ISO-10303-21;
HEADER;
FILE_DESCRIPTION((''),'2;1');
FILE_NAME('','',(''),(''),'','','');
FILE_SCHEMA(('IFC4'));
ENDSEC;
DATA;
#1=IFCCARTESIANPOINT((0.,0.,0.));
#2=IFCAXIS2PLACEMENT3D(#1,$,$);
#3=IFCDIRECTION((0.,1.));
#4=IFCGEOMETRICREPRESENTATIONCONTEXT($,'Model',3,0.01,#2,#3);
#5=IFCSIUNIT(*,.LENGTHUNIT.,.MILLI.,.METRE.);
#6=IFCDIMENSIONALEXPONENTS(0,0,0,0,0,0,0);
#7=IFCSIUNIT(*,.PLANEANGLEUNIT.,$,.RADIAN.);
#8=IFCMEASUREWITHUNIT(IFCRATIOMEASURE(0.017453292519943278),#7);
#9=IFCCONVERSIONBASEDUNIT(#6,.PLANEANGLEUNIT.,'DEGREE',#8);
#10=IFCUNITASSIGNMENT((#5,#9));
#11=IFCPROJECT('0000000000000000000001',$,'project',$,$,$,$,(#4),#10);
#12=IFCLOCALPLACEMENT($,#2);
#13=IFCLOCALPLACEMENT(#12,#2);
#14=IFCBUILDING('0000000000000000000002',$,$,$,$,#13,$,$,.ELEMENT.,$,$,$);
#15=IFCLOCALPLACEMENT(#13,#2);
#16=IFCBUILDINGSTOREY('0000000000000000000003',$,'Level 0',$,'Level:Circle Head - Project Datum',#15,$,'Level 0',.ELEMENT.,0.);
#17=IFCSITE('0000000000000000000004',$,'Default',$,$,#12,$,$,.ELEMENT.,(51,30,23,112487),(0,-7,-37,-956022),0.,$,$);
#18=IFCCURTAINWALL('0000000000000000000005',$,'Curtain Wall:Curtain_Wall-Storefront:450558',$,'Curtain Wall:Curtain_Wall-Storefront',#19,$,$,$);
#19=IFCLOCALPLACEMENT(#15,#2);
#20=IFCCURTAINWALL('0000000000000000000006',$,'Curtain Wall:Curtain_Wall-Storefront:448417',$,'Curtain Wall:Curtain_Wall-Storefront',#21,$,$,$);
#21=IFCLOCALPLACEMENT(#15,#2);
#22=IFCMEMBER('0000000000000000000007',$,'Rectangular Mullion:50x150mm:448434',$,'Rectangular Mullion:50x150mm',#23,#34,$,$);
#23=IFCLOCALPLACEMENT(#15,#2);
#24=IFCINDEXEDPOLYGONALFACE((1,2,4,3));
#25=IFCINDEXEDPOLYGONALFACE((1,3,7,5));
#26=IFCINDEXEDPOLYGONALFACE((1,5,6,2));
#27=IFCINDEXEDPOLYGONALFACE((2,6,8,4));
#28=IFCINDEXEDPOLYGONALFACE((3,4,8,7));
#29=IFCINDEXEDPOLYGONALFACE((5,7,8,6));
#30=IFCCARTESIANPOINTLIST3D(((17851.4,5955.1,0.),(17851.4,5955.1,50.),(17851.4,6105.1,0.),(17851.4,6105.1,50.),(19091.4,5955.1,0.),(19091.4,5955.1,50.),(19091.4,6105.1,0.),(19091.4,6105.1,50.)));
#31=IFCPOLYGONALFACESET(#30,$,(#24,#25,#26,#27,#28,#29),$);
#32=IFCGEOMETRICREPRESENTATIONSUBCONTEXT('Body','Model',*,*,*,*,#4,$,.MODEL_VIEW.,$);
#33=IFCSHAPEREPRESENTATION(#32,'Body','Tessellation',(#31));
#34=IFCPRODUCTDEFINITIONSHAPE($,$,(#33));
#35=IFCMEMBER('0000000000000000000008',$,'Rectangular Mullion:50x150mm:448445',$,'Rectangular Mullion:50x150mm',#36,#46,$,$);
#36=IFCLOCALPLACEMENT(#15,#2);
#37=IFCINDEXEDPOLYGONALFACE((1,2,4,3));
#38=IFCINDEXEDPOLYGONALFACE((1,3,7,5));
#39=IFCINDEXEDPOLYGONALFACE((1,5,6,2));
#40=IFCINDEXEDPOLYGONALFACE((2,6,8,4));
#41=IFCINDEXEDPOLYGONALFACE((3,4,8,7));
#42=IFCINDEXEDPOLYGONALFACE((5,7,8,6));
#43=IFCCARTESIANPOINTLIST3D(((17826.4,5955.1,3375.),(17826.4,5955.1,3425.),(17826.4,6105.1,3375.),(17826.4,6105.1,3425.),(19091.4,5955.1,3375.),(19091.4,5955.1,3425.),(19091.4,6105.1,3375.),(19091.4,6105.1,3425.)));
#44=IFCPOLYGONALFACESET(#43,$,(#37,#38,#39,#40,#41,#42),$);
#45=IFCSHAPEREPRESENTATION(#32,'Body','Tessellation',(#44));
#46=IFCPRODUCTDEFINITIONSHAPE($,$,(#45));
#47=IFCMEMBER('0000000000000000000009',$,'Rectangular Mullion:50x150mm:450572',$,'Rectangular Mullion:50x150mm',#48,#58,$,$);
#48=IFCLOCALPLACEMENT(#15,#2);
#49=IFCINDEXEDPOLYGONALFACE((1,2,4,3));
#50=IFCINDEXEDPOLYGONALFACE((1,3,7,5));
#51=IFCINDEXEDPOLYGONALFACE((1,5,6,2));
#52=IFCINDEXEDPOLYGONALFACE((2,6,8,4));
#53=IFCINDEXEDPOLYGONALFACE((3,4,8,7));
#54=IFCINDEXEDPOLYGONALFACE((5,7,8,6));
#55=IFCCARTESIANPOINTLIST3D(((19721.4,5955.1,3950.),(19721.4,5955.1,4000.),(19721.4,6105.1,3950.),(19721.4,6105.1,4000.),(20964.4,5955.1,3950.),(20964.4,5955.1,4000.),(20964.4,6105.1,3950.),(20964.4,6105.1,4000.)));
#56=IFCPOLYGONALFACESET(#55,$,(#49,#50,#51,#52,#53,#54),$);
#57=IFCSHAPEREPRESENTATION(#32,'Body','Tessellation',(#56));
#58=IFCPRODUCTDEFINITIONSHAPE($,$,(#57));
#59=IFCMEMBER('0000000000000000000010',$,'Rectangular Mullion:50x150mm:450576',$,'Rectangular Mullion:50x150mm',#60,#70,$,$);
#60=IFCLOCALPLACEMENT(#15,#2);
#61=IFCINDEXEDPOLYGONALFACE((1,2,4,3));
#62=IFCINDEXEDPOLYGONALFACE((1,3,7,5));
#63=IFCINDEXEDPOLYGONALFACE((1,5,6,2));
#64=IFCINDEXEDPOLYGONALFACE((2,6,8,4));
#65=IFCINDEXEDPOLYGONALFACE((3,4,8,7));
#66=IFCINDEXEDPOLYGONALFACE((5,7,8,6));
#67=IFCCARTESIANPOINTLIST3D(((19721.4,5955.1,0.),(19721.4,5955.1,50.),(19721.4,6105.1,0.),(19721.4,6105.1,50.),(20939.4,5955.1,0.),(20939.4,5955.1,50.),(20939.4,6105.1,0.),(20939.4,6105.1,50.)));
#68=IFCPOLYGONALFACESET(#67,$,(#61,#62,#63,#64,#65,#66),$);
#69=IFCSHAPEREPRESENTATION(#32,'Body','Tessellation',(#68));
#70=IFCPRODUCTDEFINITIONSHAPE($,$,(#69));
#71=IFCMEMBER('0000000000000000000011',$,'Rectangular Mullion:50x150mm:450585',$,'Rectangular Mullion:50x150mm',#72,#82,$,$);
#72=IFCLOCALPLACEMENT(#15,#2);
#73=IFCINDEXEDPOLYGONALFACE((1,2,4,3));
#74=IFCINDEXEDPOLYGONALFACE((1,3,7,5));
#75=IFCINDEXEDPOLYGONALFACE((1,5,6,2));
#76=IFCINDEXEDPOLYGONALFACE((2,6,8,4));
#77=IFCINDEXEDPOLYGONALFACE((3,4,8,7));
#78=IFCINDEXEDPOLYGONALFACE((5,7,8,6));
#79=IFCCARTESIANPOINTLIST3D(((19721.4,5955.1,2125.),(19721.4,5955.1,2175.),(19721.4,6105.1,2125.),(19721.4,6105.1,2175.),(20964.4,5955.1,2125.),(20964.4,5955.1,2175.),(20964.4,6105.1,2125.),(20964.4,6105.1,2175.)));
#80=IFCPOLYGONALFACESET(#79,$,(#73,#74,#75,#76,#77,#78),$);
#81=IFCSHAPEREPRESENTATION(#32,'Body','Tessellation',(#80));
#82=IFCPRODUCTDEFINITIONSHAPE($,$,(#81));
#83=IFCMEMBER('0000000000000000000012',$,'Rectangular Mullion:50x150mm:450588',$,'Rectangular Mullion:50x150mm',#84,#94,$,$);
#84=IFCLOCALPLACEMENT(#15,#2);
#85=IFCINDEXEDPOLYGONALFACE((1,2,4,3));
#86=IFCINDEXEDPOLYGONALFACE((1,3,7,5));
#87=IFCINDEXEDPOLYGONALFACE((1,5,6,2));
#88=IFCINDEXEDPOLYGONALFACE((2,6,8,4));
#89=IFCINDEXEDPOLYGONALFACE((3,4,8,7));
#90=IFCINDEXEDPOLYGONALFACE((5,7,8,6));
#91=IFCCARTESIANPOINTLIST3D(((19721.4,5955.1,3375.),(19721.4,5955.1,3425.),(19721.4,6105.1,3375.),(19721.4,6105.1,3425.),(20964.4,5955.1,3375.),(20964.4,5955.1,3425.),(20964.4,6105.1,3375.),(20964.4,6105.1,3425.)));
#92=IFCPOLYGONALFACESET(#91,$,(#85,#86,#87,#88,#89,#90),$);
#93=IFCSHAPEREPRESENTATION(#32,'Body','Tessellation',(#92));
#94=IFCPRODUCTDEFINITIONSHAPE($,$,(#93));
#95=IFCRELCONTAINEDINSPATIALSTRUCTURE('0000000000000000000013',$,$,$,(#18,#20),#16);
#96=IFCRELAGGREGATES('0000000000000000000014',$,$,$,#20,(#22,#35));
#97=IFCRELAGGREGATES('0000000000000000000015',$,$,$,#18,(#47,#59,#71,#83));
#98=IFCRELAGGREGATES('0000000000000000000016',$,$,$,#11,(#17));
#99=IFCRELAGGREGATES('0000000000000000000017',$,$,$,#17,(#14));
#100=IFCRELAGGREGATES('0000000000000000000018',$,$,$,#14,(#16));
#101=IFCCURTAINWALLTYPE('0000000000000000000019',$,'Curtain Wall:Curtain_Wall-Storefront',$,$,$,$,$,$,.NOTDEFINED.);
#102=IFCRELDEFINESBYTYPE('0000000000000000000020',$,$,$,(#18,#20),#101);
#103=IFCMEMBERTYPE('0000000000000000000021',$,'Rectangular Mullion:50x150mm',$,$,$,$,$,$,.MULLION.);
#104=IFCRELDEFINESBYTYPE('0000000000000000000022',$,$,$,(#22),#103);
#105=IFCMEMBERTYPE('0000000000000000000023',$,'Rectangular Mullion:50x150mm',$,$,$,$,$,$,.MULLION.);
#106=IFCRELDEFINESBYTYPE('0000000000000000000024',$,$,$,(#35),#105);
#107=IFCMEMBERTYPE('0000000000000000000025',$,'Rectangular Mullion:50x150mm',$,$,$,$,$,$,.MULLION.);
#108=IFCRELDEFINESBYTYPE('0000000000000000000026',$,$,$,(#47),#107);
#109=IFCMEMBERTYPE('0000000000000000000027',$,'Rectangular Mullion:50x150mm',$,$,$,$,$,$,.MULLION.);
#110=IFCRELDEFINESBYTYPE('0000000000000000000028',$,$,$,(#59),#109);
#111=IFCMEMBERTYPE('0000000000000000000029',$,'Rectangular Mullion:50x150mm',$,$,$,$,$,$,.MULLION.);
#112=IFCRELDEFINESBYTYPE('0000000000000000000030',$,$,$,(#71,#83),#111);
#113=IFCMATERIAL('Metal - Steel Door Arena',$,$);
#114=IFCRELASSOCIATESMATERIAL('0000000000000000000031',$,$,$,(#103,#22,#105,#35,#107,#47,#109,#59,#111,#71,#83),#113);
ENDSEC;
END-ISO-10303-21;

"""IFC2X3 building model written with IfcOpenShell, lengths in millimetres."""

from ifc_helpers import new_model, entity, si_unit, converted_unit, direction, frame, origin, origin_2d_with_axis, place, context, subcontext, project, spatial, rectangle, extrude, source, transform, mapped, material, type_object, type_shapes, element, aggregate, save


model = new_model("IFC2X3")

# Units and contexts
model_context = context("Model", 3, precision=0.01, world=origin(), true_north=direction((0.0, 1.0)))
body_context = subcontext(model_context, "Body", "Model", "MODEL_VIEW")
ifc_project = project(units=[si_unit("LENGTHUNIT", "METRE", prefix="MILLI"), converted_unit("PLANEANGLEUNIT", "DEGREE", entity("IfcRatioMeasure", 0.017453292519943278), si_unit("PLANEANGLEUNIT", "RADIAN"), dimensions=[0, 0, 0, 0, 0, 0, 0])], contexts=[model_context])

# Site, building, storey
site_placement = place(None, origin())
site = spatial("IfcSite", under=ifc_project, at=site_placement, Name="Default", CompositionType="ELEMENT", RefLatitude=(51, 30, 23, 112487), RefLongitude=(0, -7, -37, -956022), RefElevation=0.0)
building_placement = place(site_placement, origin())
building = spatial("IfcBuilding", under=site, at=building_placement, CompositionType="ELEMENT")
storey_placement = place(building_placement, origin())
storey = spatial("IfcBuildingStorey", under=building, at=storey_placement, Name="Level 0", ObjectType="Level:Circle Head - Project Datum", LongName="Level 0", CompositionType="ELEMENT", Elevation=0.0)

# Curtain walls
curtain_wall_type = type_object("IfcCurtainWallType", Name="Curtain Wall:Curtain_Wall-Storefront", PredefinedType="NOTDEFINED")
curtain_wall_1_placement = place(storey_placement, origin())
curtain_wall_1 = element("IfcCurtainWall", 1, at=curtain_wall_1_placement, inside=storey, type_object=curtain_wall_type, Name="Curtain Wall:Curtain_Wall-Storefront:450558", ObjectType="Curtain Wall:Curtain_Wall-Storefront")
ifc_material_1 = material(Name="Metal - Steel Door Arena")
curtain_wall_2_placement = place(storey_placement, origin())
curtain_wall_2 = element("IfcCurtainWall", 2, at=curtain_wall_2_placement, inside=storey, type_object=curtain_wall_type, Name="Curtain Wall:Curtain_Wall-Storefront:448417", ObjectType="Curtain Wall:Curtain_Wall-Storefront")

# Members
member_type_1 = type_object("IfcMemberType", Name="Rectangular Mullion:50x150mm", PredefinedType="MULLION", material=ifc_material_1)
shared_shape_1 = source(origin(), body_context, "Body", "SweptSolid", [
    extrude(rectangle(XDim=150.0, YDim=50.0, at=origin_2d_with_axis()), frame((-25.0, 0.0, -1240.0), z_axis=(0.0, 0.0, 1.0), x_axis=(0.0, -1.0, 0.0)), (0.0, 0.0, 1.0), 1240.0),
])
type_shapes(member_type_1, [shared_shape_1])
member_1_placement = place(curtain_wall_2_placement, frame((19091.4, 6030.1, 0.0), z_axis=(1.0, 0.0, 0.0), x_axis=(0.0, 0.0, -1.0)))
member_1 = element("IfcMember", 3, at=member_1_placement, type_object=member_type_1, material=ifc_material_1, Name="Rectangular Mullion:50x150mm:448434", ObjectType="Rectangular Mullion:50x150mm", context=body_context, shape_type="MappedRepresentation", body=[
    mapped(shared_shape_1, transform((0.0, 0.0, 0.0), scale=1.0)),
])
member_type_2 = type_object("IfcMemberType", Name="Rectangular Mullion:50x150mm", PredefinedType="MULLION", material=ifc_material_1)
shared_shape_2 = source(origin(), body_context, "Body", "SweptSolid", [
    extrude(rectangle(XDim=150.0, YDim=50.0, at=origin_2d_with_axis()), frame((0.0, 0.0, -1265.0), z_axis=(0.0, 0.0, 1.0), x_axis=(0.0, -1.0, 0.0)), (0.0, 0.0, 1.0), 1265.0),
])
type_shapes(member_type_2, [shared_shape_2])
member_2_placement = place(curtain_wall_2_placement, frame((17826.4, 6030.1, 3400.0), z_axis=(-1.0, 0.0, 0.0), x_axis=(0.0, 0.0, 1.0)))
member_2 = element("IfcMember", 4, at=member_2_placement, type_object=member_type_2, material=ifc_material_1, Name="Rectangular Mullion:50x150mm:448445", ObjectType="Rectangular Mullion:50x150mm", context=body_context, shape_type="MappedRepresentation", body=[
    mapped(shared_shape_2, transform((0.0, 0.0, 0.0), scale=1.0)),
])
member_type_3 = type_object("IfcMemberType", Name="Rectangular Mullion:50x150mm", PredefinedType="MULLION", material=ifc_material_1)
shared_shape_3 = source(origin(), body_context, "Body", "SweptSolid", [
    extrude(rectangle(XDim=150.0, YDim=50.0, at=origin_2d_with_axis()), frame((-25.0, 0.0, -1243.0), z_axis=(0.0, 0.0, 1.0), x_axis=(0.0, -1.0, 0.0)), (0.0, 0.0, 1.0), 1243.0),
])
type_shapes(member_type_3, [shared_shape_3])
member_3_placement = place(curtain_wall_1_placement, frame((19721.4, 6030.1, 4000.0), z_axis=(-1.0, 0.0, 0.0), x_axis=(0.0, 0.0, 1.0)))
member_3 = element("IfcMember", 5, at=member_3_placement, type_object=member_type_3, material=ifc_material_1, Name="Rectangular Mullion:50x150mm:450572", ObjectType="Rectangular Mullion:50x150mm", context=body_context, shape_type="MappedRepresentation", body=[
    mapped(shared_shape_3, transform((0.0, 0.0, 0.0), scale=1.0)),
])
member_type_4 = type_object("IfcMemberType", Name="Rectangular Mullion:50x150mm", PredefinedType="MULLION", material=ifc_material_1)
shared_shape_4 = source(origin(), body_context, "Body", "SweptSolid", [
    extrude(rectangle(XDim=150.0, YDim=50.0, at=origin_2d_with_axis()), frame((-25.0, 0.0, -1218.0), z_axis=(0.0, 0.0, 1.0), x_axis=(0.0, -1.0, 0.0)), (0.0, 0.0, 1.0), 1218.0),
])
type_shapes(member_type_4, [shared_shape_4])
member_4_placement = place(curtain_wall_1_placement, frame((20939.4, 6030.1, 0.0), z_axis=(1.0, 0.0, 0.0), x_axis=(0.0, 0.0, -1.0)))
member_4 = element("IfcMember", 6, at=member_4_placement, type_object=member_type_4, material=ifc_material_1, Name="Rectangular Mullion:50x150mm:450576", ObjectType="Rectangular Mullion:50x150mm", context=body_context, shape_type="MappedRepresentation", body=[
    mapped(shared_shape_4, transform((0.0, 0.0, 0.0), scale=1.0)),
])
member_type_5 = type_object("IfcMemberType", Name="Rectangular Mullion:50x150mm", PredefinedType="MULLION", material=ifc_material_1)
shared_shape_5 = source(origin(), body_context, "Body", "SweptSolid", [
    extrude(rectangle(XDim=150.0, YDim=50.0, at=origin_2d_with_axis()), frame((0.0, 0.0, -1243.0), z_axis=(0.0, 0.0, 1.0), x_axis=(0.0, -1.0, 0.0)), (0.0, 0.0, 1.0), 1243.0),
])
type_shapes(member_type_5, [shared_shape_5])
member_5_placement = place(curtain_wall_1_placement, frame((19721.4, 6030.1, 2150.0), z_axis=(-1.0, 0.0, 0.0), x_axis=(0.0, 0.0, 1.0)))
member_5 = element("IfcMember", 7, at=member_5_placement, type_object=member_type_5, material=ifc_material_1, Name="Rectangular Mullion:50x150mm:450585", ObjectType="Rectangular Mullion:50x150mm", context=body_context, shape_type="MappedRepresentation", body=[
    mapped(shared_shape_5, transform((0.0, 0.0, 0.0), scale=1.0)),
])
member_6_placement = place(curtain_wall_1_placement, frame((19721.4, 6030.1, 3400.0), z_axis=(-1.0, 0.0, 0.0), x_axis=(0.0, 0.0, 1.0)))
member_6 = element("IfcMember", 8, at=member_6_placement, type_object=member_type_5, material=ifc_material_1, Name="Rectangular Mullion:50x150mm:450588", ObjectType="Rectangular Mullion:50x150mm", context=body_context, shape_type="MappedRepresentation", body=[
    mapped(shared_shape_5, transform((0.0, 0.0, 0.0), scale=1.0)),
])

aggregate(curtain_wall_2, [member_1, member_2])
aggregate(curtain_wall_1, [member_3, member_4, member_5, member_6])

save(model, "model.ifc")
